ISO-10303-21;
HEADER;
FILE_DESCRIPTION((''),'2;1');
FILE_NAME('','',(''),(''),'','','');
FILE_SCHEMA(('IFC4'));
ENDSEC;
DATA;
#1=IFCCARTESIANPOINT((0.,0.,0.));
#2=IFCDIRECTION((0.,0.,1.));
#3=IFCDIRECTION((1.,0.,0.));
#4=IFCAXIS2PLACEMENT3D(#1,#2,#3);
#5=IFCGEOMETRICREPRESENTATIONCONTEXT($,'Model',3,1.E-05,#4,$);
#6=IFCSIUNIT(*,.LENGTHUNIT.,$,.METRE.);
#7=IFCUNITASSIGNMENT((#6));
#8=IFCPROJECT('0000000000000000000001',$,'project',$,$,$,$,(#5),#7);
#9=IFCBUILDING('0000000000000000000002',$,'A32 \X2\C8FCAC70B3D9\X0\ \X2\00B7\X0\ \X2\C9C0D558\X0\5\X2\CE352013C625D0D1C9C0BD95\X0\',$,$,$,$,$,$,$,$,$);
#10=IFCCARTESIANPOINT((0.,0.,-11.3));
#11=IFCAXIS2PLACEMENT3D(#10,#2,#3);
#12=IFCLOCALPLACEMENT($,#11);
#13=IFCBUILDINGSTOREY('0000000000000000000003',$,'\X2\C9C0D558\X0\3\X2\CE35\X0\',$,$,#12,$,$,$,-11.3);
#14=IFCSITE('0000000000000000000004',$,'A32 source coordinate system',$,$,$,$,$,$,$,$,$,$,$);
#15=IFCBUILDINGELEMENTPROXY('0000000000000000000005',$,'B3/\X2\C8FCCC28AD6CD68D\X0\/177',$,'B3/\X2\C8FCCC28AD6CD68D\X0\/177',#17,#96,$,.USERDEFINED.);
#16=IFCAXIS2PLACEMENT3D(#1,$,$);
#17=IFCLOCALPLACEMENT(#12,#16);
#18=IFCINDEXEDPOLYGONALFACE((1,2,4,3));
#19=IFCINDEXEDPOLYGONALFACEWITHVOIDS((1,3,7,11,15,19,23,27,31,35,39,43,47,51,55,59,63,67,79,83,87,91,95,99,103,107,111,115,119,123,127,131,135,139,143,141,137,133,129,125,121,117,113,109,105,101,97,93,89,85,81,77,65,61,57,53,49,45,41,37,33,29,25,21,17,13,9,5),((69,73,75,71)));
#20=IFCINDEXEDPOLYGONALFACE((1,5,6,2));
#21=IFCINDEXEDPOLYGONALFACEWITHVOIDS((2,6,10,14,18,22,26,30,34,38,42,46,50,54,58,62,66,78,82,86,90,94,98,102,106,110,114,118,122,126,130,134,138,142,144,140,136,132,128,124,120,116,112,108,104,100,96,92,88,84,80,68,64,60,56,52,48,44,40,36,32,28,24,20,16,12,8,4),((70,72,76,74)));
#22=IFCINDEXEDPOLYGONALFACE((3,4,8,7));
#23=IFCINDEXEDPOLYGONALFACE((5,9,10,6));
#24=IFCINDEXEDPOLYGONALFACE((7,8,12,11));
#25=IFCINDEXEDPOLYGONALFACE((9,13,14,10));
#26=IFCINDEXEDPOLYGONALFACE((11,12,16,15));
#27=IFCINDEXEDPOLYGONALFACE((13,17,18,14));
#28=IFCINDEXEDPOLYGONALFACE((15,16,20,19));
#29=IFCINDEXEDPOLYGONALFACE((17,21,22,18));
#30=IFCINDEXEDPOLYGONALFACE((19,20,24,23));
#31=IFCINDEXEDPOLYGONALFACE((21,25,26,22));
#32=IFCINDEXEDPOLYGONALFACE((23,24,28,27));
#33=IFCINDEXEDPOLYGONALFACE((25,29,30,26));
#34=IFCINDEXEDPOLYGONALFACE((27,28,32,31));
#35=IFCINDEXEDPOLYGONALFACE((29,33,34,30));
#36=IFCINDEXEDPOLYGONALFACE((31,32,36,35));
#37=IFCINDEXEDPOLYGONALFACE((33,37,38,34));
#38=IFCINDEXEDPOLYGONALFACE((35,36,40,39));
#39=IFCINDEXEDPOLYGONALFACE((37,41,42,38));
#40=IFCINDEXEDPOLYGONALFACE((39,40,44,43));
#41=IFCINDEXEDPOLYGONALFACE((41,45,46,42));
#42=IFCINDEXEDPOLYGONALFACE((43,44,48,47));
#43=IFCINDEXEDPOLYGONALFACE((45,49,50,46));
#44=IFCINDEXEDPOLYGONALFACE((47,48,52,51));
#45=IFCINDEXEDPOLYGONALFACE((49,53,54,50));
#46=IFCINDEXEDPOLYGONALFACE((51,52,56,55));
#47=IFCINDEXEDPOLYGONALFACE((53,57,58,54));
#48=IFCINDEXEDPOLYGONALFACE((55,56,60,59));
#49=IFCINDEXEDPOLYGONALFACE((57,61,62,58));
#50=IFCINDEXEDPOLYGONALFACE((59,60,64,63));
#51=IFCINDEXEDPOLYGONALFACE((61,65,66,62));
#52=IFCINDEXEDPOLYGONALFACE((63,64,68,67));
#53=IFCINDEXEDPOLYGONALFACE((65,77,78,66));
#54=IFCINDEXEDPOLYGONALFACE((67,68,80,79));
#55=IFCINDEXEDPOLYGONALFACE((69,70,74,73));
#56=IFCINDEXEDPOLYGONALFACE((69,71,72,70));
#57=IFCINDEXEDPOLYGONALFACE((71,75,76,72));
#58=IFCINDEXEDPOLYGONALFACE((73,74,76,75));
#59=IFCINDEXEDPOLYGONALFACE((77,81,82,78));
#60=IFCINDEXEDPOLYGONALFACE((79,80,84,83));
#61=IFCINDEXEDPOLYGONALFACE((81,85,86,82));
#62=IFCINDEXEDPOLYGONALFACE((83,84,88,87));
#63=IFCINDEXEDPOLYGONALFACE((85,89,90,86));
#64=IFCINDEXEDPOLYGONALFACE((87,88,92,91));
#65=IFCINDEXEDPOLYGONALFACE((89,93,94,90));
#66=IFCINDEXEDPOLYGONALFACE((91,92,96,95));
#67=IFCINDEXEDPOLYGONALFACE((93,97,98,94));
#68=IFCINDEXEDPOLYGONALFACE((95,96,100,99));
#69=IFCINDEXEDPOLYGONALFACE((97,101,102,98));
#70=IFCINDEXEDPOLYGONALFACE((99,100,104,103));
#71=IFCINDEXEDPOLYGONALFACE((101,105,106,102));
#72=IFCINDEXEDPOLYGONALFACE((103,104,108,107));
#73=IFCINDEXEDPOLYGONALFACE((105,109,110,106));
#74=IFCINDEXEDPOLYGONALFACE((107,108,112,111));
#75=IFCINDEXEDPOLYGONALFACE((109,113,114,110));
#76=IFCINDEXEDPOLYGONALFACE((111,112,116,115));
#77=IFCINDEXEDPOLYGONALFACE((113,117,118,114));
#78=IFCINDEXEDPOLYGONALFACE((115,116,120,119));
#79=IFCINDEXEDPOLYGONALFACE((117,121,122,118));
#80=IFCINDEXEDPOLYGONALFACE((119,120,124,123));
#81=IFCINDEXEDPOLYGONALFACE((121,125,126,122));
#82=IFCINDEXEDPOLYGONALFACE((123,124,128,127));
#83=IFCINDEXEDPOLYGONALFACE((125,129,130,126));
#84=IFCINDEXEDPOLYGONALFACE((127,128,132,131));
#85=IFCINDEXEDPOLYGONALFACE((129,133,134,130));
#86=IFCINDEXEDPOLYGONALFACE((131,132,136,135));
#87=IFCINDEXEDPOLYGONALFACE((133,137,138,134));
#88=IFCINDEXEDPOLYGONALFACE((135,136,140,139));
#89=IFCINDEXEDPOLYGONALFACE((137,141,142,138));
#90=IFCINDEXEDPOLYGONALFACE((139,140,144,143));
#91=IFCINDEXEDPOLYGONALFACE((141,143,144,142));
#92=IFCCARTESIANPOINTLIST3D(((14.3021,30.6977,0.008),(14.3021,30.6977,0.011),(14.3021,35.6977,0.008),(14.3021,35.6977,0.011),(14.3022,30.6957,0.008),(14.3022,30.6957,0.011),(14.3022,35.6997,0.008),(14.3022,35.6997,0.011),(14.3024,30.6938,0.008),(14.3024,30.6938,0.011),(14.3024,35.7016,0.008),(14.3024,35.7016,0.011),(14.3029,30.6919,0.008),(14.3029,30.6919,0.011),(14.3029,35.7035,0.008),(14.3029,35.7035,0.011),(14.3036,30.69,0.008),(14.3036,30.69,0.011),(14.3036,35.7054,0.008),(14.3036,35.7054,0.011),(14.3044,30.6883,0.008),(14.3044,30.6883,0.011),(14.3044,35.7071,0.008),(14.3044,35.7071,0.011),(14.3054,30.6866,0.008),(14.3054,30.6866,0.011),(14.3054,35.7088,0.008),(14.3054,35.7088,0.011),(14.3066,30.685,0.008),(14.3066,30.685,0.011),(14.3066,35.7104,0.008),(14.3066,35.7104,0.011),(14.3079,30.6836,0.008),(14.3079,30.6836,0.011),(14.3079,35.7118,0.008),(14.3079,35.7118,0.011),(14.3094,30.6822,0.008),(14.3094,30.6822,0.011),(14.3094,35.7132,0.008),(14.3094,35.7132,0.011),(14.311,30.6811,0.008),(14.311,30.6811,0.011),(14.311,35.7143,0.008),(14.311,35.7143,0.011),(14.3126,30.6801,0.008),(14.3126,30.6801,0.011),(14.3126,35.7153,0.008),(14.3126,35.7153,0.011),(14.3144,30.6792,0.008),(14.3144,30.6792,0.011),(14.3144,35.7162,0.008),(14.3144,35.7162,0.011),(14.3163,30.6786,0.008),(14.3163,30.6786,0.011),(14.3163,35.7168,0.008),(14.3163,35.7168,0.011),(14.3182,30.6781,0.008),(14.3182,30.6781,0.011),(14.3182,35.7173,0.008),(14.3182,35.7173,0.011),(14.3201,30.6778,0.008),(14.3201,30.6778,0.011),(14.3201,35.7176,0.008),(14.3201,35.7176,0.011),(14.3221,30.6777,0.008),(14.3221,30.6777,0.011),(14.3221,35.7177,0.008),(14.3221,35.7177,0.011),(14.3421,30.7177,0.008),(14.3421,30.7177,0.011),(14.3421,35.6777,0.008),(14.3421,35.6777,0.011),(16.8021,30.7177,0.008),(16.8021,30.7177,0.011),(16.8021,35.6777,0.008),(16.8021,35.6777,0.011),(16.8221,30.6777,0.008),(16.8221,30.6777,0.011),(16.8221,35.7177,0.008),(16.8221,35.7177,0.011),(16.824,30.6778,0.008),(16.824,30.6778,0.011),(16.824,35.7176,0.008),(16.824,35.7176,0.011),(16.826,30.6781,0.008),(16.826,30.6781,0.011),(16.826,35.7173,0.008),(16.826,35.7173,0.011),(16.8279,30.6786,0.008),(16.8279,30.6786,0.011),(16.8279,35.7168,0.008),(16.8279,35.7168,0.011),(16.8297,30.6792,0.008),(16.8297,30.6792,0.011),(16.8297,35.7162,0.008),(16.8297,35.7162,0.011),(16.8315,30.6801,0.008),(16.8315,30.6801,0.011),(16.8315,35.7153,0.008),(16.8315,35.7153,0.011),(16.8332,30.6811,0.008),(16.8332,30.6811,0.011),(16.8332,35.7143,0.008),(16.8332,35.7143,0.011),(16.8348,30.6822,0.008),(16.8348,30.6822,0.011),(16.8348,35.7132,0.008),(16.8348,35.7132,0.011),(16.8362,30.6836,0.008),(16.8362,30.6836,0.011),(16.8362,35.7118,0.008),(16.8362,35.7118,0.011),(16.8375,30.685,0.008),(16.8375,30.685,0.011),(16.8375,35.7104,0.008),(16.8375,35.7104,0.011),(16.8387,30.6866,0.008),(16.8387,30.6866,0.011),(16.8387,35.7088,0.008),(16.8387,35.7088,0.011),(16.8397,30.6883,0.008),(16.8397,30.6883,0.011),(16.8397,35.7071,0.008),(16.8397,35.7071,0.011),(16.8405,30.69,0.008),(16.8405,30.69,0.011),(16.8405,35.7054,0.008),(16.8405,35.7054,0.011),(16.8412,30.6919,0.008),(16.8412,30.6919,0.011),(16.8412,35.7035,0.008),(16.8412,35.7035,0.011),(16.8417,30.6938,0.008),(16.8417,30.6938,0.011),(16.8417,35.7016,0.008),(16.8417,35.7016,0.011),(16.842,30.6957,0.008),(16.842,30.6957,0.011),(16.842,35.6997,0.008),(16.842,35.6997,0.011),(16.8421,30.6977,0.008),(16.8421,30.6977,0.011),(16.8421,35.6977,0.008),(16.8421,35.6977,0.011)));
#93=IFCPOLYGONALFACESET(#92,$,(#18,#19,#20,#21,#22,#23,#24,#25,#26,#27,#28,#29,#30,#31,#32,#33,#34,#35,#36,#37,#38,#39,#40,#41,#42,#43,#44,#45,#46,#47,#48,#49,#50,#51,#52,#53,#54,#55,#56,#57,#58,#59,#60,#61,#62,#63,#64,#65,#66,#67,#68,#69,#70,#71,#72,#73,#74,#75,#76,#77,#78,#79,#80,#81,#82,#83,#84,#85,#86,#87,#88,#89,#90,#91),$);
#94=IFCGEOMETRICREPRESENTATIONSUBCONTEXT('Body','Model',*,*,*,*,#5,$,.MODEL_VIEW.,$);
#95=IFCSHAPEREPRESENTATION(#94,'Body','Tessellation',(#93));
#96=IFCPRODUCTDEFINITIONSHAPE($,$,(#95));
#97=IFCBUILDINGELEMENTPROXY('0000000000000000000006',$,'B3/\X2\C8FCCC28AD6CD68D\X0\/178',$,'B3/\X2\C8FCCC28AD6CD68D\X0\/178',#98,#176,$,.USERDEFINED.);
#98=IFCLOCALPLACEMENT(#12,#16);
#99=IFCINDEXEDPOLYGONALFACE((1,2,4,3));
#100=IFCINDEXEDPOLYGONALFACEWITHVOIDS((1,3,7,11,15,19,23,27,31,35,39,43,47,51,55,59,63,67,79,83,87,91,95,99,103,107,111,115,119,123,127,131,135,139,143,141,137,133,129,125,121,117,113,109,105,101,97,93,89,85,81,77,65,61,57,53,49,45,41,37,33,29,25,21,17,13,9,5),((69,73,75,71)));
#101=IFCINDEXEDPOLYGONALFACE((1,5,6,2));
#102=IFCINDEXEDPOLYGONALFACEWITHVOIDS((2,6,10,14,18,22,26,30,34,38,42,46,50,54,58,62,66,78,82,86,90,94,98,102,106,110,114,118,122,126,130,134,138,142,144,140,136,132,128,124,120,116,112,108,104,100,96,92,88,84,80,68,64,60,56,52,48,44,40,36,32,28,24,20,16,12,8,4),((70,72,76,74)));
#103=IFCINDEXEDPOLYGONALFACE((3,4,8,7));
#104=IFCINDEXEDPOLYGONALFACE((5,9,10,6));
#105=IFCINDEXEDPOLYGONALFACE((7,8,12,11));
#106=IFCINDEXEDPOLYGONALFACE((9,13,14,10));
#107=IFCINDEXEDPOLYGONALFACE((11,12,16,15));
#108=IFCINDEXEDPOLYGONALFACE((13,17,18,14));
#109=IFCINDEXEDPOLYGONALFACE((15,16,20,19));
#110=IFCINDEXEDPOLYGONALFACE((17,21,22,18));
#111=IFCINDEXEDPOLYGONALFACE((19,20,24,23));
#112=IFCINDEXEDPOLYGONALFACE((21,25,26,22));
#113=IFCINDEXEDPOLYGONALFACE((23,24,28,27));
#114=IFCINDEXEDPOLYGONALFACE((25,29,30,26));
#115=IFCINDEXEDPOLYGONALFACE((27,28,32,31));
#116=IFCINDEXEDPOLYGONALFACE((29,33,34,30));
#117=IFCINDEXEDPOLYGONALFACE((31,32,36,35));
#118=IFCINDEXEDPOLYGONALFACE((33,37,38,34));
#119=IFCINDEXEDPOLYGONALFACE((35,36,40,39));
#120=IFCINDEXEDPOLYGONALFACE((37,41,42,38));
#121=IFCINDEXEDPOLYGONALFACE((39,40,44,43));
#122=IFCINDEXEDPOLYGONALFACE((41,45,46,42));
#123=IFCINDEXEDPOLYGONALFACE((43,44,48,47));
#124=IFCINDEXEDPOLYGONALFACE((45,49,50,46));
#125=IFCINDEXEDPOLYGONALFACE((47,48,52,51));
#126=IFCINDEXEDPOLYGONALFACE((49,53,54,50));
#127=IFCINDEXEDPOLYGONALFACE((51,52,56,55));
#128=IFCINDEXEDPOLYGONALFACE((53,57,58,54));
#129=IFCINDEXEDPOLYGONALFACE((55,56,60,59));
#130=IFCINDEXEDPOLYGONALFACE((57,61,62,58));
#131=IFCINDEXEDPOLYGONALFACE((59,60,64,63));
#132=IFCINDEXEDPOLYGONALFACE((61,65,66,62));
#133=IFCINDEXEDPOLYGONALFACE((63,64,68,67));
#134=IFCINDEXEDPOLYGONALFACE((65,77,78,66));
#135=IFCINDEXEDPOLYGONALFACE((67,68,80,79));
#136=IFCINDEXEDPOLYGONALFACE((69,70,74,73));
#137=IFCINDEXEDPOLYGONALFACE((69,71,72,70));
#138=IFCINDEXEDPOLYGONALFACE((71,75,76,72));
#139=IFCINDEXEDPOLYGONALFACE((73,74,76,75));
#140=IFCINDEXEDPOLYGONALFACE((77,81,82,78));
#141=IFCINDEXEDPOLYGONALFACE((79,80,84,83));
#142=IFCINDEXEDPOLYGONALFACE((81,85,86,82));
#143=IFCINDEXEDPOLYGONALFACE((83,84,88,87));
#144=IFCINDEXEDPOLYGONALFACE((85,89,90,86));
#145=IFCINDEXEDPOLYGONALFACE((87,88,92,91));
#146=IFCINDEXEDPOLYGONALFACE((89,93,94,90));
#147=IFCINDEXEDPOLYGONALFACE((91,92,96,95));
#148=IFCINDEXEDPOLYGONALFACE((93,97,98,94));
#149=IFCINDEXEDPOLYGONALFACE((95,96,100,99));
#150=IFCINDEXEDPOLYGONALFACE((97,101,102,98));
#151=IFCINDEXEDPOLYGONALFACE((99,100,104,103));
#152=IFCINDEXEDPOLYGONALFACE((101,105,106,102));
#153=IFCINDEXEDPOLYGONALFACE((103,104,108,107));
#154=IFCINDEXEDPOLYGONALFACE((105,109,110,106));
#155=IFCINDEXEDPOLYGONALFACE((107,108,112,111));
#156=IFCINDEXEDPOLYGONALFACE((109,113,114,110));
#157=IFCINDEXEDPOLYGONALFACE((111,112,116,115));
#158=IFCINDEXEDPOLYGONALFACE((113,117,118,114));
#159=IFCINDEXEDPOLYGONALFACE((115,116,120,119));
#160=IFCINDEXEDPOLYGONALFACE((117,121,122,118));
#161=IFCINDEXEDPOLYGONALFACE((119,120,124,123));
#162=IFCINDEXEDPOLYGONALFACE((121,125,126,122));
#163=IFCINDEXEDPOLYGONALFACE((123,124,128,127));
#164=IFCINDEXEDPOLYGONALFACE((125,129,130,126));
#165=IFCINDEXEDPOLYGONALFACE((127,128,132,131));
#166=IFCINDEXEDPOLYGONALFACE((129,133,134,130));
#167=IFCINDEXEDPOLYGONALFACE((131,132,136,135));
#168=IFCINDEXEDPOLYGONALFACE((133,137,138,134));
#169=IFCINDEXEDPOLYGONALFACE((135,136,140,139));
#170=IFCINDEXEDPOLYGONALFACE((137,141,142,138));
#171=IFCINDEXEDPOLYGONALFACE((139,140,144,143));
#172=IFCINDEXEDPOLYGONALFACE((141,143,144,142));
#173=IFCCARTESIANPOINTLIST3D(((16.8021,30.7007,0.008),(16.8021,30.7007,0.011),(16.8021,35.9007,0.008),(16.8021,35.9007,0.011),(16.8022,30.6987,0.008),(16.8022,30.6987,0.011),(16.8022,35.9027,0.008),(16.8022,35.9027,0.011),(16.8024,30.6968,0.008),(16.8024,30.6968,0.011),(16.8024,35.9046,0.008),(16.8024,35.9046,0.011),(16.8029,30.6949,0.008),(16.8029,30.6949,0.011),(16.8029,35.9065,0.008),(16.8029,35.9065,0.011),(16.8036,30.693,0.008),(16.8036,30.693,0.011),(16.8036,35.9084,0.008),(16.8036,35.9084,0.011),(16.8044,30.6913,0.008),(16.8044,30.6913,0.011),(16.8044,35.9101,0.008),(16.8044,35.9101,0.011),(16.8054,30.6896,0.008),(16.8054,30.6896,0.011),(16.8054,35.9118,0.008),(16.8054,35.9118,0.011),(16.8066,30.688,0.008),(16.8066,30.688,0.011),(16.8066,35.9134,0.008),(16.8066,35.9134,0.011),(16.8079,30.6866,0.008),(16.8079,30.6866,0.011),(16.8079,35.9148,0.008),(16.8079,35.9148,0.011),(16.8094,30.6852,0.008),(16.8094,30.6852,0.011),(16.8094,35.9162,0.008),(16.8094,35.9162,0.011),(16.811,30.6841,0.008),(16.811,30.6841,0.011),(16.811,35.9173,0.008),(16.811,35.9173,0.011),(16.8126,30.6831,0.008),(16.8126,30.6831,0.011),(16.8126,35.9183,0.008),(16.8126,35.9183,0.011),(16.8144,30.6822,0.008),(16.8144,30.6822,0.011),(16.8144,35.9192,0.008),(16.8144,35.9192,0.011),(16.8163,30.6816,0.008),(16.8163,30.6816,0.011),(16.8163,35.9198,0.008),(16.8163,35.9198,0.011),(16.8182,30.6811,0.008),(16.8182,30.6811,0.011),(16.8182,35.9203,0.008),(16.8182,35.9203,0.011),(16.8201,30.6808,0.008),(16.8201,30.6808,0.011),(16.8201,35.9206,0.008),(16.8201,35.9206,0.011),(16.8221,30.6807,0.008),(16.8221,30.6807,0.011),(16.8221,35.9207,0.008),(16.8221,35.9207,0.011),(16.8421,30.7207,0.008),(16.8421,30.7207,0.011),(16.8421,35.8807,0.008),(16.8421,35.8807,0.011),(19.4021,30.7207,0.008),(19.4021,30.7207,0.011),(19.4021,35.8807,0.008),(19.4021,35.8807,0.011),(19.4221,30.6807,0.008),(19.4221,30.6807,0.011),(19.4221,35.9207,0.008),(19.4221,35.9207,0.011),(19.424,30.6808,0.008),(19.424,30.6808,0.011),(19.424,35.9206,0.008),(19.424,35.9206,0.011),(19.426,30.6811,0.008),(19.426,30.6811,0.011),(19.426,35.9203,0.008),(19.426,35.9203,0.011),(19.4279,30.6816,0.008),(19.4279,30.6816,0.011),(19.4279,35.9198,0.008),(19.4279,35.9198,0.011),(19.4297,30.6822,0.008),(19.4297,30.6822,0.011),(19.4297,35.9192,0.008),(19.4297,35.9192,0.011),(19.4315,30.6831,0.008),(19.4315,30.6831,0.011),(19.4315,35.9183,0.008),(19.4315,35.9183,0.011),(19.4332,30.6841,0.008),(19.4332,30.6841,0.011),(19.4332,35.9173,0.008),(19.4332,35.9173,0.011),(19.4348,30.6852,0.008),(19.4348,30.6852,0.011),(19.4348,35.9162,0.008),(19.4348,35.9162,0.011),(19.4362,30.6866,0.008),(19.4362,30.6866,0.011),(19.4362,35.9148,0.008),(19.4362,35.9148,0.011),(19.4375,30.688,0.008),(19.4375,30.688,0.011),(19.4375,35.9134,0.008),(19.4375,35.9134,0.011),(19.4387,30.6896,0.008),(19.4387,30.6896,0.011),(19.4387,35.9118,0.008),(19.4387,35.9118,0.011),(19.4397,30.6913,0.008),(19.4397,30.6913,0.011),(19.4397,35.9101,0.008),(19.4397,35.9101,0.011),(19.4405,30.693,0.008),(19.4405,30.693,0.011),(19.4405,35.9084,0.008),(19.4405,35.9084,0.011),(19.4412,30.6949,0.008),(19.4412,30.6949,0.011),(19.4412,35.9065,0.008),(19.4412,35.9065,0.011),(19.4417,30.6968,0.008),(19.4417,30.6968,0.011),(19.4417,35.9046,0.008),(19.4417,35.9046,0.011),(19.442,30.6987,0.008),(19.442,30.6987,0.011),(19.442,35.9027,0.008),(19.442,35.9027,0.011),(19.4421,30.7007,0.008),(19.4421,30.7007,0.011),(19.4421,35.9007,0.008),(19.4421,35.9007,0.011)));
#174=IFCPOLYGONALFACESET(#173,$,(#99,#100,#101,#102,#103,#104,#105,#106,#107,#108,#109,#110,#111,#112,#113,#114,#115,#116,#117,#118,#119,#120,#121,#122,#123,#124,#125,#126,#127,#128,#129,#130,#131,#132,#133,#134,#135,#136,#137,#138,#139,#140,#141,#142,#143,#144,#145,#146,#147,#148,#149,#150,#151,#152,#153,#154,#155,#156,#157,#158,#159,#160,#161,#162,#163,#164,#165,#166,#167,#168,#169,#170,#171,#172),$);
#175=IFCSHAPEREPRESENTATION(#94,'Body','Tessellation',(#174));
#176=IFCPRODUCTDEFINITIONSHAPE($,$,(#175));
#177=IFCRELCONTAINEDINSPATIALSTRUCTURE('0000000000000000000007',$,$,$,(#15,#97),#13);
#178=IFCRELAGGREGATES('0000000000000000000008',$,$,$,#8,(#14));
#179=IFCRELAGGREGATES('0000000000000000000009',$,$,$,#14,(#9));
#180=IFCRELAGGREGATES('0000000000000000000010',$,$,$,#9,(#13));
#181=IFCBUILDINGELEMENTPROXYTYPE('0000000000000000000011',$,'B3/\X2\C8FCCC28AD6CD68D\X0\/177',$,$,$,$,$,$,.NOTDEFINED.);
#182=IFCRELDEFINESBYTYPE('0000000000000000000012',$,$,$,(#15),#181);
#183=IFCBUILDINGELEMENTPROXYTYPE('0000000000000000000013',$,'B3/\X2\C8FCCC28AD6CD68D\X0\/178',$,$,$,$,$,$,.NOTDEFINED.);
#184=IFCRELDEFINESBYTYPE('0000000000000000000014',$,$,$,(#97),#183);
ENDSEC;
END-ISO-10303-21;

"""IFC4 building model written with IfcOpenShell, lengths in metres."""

from ifc_helpers import new_model, si_unit, frame, origin, origin_with_axes, place, context, subcontext, project, spatial, polyline, outline, extrude, source, transform, mapped, type_object, type_shapes, element, save


model = new_model("IFC4")

# Units and contexts
model_context = context("Model", 3, precision=1e-05, world=origin_with_axes())
body_context = subcontext(model_context, "Body", "Model", "MODEL_VIEW")
ifc_project = project(units=[si_unit("LENGTHUNIT", "METRE")], contexts=[model_context])

# Site, building, storey
site = spatial("IfcSite", under=ifc_project, Name="A32 source coordinate system")
building = spatial("IfcBuilding", under=site, Name="A32 주거동 · 지하5층–옥탑지붕")
storey_placement = place(None, frame((0.0, 0.0, -11.3), z_axis=(0.0, 0.0, 1.0), x_axis=(1.0, 0.0, 0.0)))
storey = spatial("IfcBuildingStorey", under=building, at=storey_placement, Name="지하3층", Elevation=-11.3)

# Building element proxies
building_element_proxy_type_1 = type_object("IfcBuildingElementProxyType", Name="B3/주차구획/177", PredefinedType="NOTDEFINED")
shared_shape_1 = source(origin(), body_context, "Body", "SweptSolid", [
    extrude(outline(polyline([(14.3021, 35.6977), (14.3022, 35.6997), (14.3024, 35.7016), (14.3029, 35.7035), (14.3036, 35.7054), (14.3044, 35.7071), (14.3054, 35.7088), (14.3066, 35.7104), (14.3079, 35.7118), (14.3094, 35.7132), (14.311, 35.7143), (14.3126, 35.7153), (14.3144, 35.7162), (14.3163, 35.7168), (14.3182, 35.7173), (14.3201, 35.7176), (14.3221, 35.7177), (16.8221, 35.7177), (16.824, 35.7176), (16.826, 35.7173), (16.8279, 35.7168), (16.8297, 35.7162), (16.8315, 35.7153), (16.8332, 35.7143), (16.8348, 35.7132), (16.8362, 35.7118), (16.8375, 35.7104), (16.8387, 35.7088), (16.8397, 35.7071), (16.8405, 35.7054), (16.8412, 35.7035), (16.8417, 35.7016), (16.842, 35.6997), (16.8421, 35.6977), (16.8421, 30.6977), (16.842, 30.6957), (16.8417, 30.6938), (16.8412, 30.6919), (16.8405, 30.69), (16.8397, 30.6883), (16.8387, 30.6866), (16.8375, 30.685), (16.8362, 30.6836), (16.8348, 30.6822), (16.8332, 30.6811), (16.8315, 30.6801), (16.8297, 30.6792), (16.8279, 30.6786), (16.826, 30.6781), (16.824, 30.6778), (16.8221, 30.6777), (14.3221, 30.6777), (14.3201, 30.6778), (14.3182, 30.6781), (14.3163, 30.6786), (14.3144, 30.6792), (14.3126, 30.6801), (14.311, 30.6811), (14.3094, 30.6822), (14.3079, 30.6836), (14.3066, 30.685), (14.3054, 30.6866), (14.3044, 30.6883), (14.3036, 30.69), (14.3029, 30.6919), (14.3024, 30.6938), (14.3022, 30.6957), (14.3021, 30.6977), (14.3021, 35.6977)]), holes=[polyline([(14.3421, 35.6777), (14.3421, 30.7177), (16.8021, 30.7177), (16.8021, 35.6777), (14.3421, 35.6777)])]), frame((0.0, 0.0, 0.008)), (0.0, 0.0, 1.0), 0.003),
])
type_shapes(building_element_proxy_type_1, [shared_shape_1])
proxy_1_placement = place(storey_placement, origin_with_axes())
element("IfcBuildingElementProxy", 1, at=proxy_1_placement, inside=storey, type_object=building_element_proxy_type_1, Name="B3/주차구획/177", ObjectType="B3/주차구획/177", PredefinedType="USERDEFINED", context=body_context, shape_type="MappedRepresentation", body=[
    mapped(shared_shape_1, transform((0.0, 0.0, 0.0), scale=1.0)),
])
building_element_proxy_type_2 = type_object("IfcBuildingElementProxyType", Name="B3/주차구획/178", PredefinedType="NOTDEFINED")
shared_shape_2 = source(origin(), body_context, "Body", "SweptSolid", [
    extrude(outline(polyline([(16.8021, 35.9007), (16.8022, 35.9027), (16.8024, 35.9046), (16.8029, 35.9065), (16.8036, 35.9084), (16.8044, 35.9101), (16.8054, 35.9118), (16.8066, 35.9134), (16.8079, 35.9148), (16.8094, 35.9162), (16.811, 35.9173), (16.8126, 35.9183), (16.8144, 35.9192), (16.8163, 35.9198), (16.8182, 35.9203), (16.8201, 35.9206), (16.8221, 35.9207), (19.4221, 35.9207), (19.424, 35.9206), (19.426, 35.9203), (19.4279, 35.9198), (19.4297, 35.9192), (19.4315, 35.9183), (19.4332, 35.9173), (19.4348, 35.9162), (19.4362, 35.9148), (19.4375, 35.9134), (19.4387, 35.9118), (19.4397, 35.9101), (19.4405, 35.9084), (19.4412, 35.9065), (19.4417, 35.9046), (19.442, 35.9027), (19.4421, 35.9007), (19.4421, 30.7007), (19.442, 30.6987), (19.4417, 30.6968), (19.4412, 30.6949), (19.4405, 30.693), (19.4397, 30.6913), (19.4387, 30.6896), (19.4375, 30.688), (19.4362, 30.6866), (19.4348, 30.6852), (19.4332, 30.6841), (19.4315, 30.6831), (19.4297, 30.6822), (19.4279, 30.6816), (19.426, 30.6811), (19.424, 30.6808), (19.4221, 30.6807), (16.8221, 30.6807), (16.8201, 30.6808), (16.8182, 30.6811), (16.8163, 30.6816), (16.8144, 30.6822), (16.8126, 30.6831), (16.811, 30.6841), (16.8094, 30.6852), (16.8079, 30.6866), (16.8066, 30.688), (16.8054, 30.6896), (16.8044, 30.6913), (16.8036, 30.693), (16.8029, 30.6949), (16.8024, 30.6968), (16.8022, 30.6987), (16.8021, 30.7007), (16.8021, 35.9007)]), holes=[polyline([(16.8421, 35.8807), (16.8421, 30.7207), (19.4021, 30.7207), (19.4021, 35.8807), (16.8421, 35.8807)])]), frame((0.0, 0.0, 0.008)), (0.0, 0.0, 1.0), 0.003),
])
type_shapes(building_element_proxy_type_2, [shared_shape_2])
proxy_2_placement = place(storey_placement, origin_with_axes())
element("IfcBuildingElementProxy", 2, at=proxy_2_placement, inside=storey, type_object=building_element_proxy_type_2, Name="B3/주차구획/178", ObjectType="B3/주차구획/178", PredefinedType="USERDEFINED", context=body_context, shape_type="MappedRepresentation", body=[
    mapped(shared_shape_2, transform((0.0, 0.0, 0.0), scale=1.0)),
])

save(model, "model.ifc")
